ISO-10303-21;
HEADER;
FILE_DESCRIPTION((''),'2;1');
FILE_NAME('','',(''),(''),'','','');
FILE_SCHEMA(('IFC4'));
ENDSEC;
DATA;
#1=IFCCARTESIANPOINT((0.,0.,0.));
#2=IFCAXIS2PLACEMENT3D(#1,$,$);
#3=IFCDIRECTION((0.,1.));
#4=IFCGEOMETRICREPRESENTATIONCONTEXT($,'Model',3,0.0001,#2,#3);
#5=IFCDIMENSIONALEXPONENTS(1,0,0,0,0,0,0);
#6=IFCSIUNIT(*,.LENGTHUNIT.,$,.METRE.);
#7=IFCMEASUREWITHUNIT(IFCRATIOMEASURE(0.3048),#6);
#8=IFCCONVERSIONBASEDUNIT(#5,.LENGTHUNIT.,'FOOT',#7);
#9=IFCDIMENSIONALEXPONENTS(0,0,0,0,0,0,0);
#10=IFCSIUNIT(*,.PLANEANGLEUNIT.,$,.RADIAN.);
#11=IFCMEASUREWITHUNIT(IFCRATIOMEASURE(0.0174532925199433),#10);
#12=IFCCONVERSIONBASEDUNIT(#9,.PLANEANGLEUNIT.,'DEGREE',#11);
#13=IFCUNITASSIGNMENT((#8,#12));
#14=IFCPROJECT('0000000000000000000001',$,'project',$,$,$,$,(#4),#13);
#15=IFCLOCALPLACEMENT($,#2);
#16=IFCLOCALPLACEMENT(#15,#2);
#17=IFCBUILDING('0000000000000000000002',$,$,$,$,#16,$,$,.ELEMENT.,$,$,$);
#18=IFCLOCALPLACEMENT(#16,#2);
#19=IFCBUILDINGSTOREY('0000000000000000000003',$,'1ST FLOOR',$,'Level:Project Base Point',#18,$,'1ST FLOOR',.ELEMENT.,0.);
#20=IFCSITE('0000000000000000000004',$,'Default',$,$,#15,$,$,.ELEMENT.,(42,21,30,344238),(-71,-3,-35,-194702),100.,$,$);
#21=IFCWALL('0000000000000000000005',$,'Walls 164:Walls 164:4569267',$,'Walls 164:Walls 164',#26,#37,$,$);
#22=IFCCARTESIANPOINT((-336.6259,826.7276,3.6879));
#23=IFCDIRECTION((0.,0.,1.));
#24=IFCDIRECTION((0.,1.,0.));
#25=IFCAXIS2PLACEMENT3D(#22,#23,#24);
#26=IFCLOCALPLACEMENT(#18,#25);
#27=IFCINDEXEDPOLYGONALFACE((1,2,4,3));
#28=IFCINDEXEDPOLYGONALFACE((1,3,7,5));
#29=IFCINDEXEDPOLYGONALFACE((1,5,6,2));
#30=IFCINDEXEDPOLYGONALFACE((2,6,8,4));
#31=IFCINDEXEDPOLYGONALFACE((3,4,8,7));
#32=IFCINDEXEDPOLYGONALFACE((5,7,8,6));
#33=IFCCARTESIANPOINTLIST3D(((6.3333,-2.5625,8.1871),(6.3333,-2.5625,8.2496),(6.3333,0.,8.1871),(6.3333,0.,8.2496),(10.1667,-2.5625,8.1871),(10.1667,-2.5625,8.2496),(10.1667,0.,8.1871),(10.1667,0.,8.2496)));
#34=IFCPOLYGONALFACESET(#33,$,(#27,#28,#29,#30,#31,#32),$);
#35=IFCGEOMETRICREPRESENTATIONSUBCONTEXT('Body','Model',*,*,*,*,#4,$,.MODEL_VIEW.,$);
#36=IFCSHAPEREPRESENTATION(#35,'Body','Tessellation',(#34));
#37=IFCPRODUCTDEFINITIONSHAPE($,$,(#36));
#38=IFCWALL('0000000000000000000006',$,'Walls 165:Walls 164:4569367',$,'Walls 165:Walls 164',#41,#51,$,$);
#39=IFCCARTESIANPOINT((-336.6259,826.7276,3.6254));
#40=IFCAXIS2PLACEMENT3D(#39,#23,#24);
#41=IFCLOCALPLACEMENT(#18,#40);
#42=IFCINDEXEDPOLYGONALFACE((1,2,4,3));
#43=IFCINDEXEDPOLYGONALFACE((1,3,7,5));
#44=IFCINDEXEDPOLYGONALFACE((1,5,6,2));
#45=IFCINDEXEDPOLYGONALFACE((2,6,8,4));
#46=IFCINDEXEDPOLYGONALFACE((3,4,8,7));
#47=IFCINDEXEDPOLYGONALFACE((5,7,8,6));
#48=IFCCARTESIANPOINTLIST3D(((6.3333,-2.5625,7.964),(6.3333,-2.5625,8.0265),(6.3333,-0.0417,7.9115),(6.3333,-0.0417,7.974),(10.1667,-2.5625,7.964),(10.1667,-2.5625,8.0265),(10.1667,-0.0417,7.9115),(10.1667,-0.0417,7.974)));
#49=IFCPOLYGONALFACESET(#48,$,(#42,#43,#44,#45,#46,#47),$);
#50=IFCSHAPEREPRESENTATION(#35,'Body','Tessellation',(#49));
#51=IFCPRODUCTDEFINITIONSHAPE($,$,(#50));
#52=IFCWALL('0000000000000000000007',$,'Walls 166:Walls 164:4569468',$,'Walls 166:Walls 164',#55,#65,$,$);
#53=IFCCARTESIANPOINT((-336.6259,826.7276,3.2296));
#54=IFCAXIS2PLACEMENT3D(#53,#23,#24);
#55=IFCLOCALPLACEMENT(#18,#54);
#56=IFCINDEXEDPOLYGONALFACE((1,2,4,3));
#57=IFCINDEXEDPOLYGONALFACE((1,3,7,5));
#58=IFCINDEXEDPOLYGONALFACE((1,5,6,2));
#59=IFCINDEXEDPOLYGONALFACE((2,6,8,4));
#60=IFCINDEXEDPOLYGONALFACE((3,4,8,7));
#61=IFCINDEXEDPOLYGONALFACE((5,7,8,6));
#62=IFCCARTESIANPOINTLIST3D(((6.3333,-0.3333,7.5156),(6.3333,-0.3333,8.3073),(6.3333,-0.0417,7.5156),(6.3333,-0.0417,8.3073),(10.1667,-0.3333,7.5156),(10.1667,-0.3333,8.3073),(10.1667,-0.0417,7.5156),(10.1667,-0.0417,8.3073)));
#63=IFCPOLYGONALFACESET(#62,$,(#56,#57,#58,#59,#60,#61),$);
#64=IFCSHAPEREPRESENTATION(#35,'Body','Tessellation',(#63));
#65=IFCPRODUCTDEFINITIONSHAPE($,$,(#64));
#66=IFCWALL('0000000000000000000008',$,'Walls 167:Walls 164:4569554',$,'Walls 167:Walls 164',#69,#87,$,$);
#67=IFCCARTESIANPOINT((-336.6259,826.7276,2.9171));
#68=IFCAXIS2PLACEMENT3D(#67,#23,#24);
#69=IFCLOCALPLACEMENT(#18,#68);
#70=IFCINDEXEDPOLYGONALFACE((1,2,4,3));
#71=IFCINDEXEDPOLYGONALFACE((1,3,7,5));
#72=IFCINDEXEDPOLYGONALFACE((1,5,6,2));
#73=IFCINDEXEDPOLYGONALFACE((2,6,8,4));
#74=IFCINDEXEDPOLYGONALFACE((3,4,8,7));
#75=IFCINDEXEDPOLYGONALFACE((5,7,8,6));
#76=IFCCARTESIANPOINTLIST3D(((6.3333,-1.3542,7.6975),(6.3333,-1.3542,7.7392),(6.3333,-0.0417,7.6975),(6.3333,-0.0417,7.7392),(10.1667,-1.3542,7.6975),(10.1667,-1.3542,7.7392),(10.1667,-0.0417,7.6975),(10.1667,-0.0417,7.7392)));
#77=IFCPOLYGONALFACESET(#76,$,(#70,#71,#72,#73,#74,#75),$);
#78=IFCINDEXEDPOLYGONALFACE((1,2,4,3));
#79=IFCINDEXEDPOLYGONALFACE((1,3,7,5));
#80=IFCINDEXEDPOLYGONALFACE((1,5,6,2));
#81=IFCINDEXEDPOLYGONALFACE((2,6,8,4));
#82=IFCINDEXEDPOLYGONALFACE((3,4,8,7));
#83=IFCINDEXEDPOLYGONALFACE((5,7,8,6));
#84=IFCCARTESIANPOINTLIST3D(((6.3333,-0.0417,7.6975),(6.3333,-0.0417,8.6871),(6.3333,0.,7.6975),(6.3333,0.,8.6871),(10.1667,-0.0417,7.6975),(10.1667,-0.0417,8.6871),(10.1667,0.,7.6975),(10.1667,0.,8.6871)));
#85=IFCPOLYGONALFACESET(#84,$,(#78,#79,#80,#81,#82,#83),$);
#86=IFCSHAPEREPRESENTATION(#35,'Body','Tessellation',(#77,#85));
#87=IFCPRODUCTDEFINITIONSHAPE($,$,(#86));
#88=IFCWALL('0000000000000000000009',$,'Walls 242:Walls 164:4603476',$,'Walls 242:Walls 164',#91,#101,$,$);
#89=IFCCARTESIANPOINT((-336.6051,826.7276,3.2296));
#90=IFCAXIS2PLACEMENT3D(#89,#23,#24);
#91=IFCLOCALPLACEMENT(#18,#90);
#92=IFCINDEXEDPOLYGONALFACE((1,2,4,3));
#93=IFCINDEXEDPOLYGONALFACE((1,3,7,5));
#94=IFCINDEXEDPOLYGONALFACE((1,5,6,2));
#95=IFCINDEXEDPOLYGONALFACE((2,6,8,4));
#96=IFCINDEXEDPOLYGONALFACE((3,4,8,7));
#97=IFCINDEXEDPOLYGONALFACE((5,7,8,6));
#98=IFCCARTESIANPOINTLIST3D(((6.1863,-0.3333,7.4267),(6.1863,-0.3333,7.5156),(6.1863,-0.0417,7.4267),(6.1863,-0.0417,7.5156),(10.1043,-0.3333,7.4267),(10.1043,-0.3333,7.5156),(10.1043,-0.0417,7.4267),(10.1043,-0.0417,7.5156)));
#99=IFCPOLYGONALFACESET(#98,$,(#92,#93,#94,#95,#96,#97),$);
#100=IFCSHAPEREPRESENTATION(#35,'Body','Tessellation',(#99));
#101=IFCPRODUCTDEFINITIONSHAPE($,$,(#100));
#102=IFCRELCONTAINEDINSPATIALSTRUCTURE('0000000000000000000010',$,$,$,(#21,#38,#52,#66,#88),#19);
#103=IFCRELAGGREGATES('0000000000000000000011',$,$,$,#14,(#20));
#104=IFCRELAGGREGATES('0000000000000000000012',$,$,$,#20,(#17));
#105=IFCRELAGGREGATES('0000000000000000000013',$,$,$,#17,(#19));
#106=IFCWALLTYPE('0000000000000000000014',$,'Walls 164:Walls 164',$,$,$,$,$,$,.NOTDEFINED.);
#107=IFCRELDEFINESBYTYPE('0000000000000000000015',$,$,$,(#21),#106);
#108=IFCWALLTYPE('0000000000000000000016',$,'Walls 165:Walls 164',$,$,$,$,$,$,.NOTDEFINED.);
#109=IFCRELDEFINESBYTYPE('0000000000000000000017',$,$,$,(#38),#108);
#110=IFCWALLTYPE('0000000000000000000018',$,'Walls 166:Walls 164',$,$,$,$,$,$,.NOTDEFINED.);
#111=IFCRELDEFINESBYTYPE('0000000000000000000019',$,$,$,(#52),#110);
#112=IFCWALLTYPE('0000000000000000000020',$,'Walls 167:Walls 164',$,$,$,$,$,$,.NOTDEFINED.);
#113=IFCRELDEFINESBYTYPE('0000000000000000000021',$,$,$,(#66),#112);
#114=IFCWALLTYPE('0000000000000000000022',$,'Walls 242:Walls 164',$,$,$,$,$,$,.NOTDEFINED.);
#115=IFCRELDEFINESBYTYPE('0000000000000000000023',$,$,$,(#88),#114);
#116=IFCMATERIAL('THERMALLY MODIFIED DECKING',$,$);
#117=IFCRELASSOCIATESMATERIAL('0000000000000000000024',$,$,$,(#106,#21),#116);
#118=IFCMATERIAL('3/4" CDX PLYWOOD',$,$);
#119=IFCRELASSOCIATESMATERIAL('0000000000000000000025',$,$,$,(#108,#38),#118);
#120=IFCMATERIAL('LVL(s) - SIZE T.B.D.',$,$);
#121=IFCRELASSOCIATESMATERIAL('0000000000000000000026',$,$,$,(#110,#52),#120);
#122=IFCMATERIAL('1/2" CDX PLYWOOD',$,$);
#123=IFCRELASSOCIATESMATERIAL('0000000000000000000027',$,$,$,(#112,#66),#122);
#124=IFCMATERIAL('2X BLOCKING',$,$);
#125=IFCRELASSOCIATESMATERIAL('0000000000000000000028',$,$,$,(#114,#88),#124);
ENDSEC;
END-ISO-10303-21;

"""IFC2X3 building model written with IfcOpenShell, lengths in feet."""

from ifc_helpers import new_model, entity, si_unit, converted_unit, direction, frame, frame_2d, origin, place, context, subcontext, project, spatial, rectangle, extrude, material, type_object, element, save


model = new_model("IFC2X3")

# Units and contexts
model_context = context("Model", 3, precision=0.0001, world=origin(), true_north=direction((0.0, 1.0)))
body_context = subcontext(model_context, "Body", "Model", "MODEL_VIEW")
ifc_project = project(units=[converted_unit("LENGTHUNIT", "FOOT", entity("IfcRatioMeasure", 0.3048), si_unit("LENGTHUNIT", "METRE"), dimensions=[1, 0, 0, 0, 0, 0, 0]), converted_unit("PLANEANGLEUNIT", "DEGREE", entity("IfcRatioMeasure", 0.0174532925199433), si_unit("PLANEANGLEUNIT", "RADIAN"), dimensions=[0, 0, 0, 0, 0, 0, 0])], contexts=[model_context])

# Site, building, storey
site_placement = place(None, origin())
site = spatial("IfcSite", under=ifc_project, at=site_placement, Name="Default", CompositionType="ELEMENT", RefLatitude=(42, 21, 30, 344238), RefLongitude=(-71, -3, -35, -194702), RefElevation=100.0)
building_placement = place(site_placement, origin())
building = spatial("IfcBuilding", under=site, at=building_placement, CompositionType="ELEMENT")
storey_placement = place(building_placement, origin())
storey = spatial("IfcBuildingStorey", under=building, at=storey_placement, Name="1ST FLOOR", ObjectType="Level:Project Base Point", LongName="1ST FLOOR", CompositionType="ELEMENT", Elevation=0.0)

# Walls
ifc_material_1 = material(Name="1/2\" CDX PLYWOOD")
ifc_material_2 = material(Name="LVL(s) - SIZE T.B.D.")
ifc_material_3 = material(Name="2X BLOCKING")
ifc_material_4 = material(Name="THERMALLY MODIFIED DECKING")
wall_type_1 = type_object("IfcWallType", Name="Walls 164:Walls 164", PredefinedType="NOTDEFINED", material=ifc_material_4)
wall_1_placement = place(storey_placement, frame((-336.6259, 826.7276, 3.6879), z_axis=(0.0, 0.0, 1.0), x_axis=(0.0, 1.0, 0.0)))
element("IfcWall", 1, at=wall_1_placement, inside=storey, type_object=wall_type_1, material=ifc_material_4, Name="Walls 164:Walls 164:4569267", ObjectType="Walls 164:Walls 164", context=body_context, shape_type="SweptSolid", body=[
    extrude(rectangle(XDim=3.8333, YDim=2.5625, at=frame_2d((0.0, 0.0), x_axis=(1.0, 0.0))), frame((8.25, -1.2813, 8.1871)), (0.0, 0.0, 1.0), 0.0625),
])
ifc_material_5 = material(Name="3/4\" CDX PLYWOOD")
wall_type_2 = type_object("IfcWallType", Name="Walls 165:Walls 164", PredefinedType="NOTDEFINED", material=ifc_material_5)
wall_2_placement = place(storey_placement, frame((-336.6259, 826.7276, 3.6254), z_axis=(0.0, 0.0, 1.0), x_axis=(0.0, 1.0, 0.0)))
element("IfcWall", 2, at=wall_2_placement, inside=storey, type_object=wall_type_2, material=ifc_material_5, Name="Walls 165:Walls 164:4569367", ObjectType="Walls 165:Walls 164", context=body_context, shape_type="SweptSolid", body=[
    extrude(rectangle(XDim=2.5214, YDim=3.8333, at=frame_2d((0.0, 0.0), x_axis=(0.0, 1.0))), frame((8.25, -1.3021, 7.9377), z_axis=(0.0, 0.020829, 0.999783), x_axis=(1.0, 0.0, 0.0)), (0.0, -0.020829, 0.999783), 0.0625),
])
wall_type_3 = type_object("IfcWallType", Name="Walls 166:Walls 164", PredefinedType="NOTDEFINED", material=ifc_material_2)
wall_3_placement = place(storey_placement, frame((-336.6259, 826.7276, 3.2296), z_axis=(0.0, 0.0, 1.0), x_axis=(0.0, 1.0, 0.0)))
element("IfcWall", 3, at=wall_3_placement, inside=storey, type_object=wall_type_3, material=ifc_material_2, Name="Walls 166:Walls 164:4569468", ObjectType="Walls 166:Walls 164", context=body_context, shape_type="SweptSolid", body=[
    extrude(rectangle(XDim=3.8333, YDim=0.2917, at=frame_2d((0.0, 0.0), x_axis=(1.0, 0.0))), frame((8.25, -0.1875, 7.5156)), (0.0, 0.0, 1.0), 0.7917),
])
wall_type_4 = type_object("IfcWallType", Name="Walls 167:Walls 164", PredefinedType="NOTDEFINED", material=ifc_material_1)
wall_4_placement = place(storey_placement, frame((-336.6259, 826.7276, 2.9171), z_axis=(0.0, 0.0, 1.0), x_axis=(0.0, 1.0, 0.0)))
element("IfcWall", 4, at=wall_4_placement, inside=storey, type_object=wall_type_4, material=ifc_material_1, Name="Walls 167:Walls 164:4569554", ObjectType="Walls 167:Walls 164", context=body_context, shape_type="SweptSolid", body=[
    extrude(rectangle(XDim=3.8333, YDim=1.3125, at=frame_2d((0.0, 0.0), x_axis=(1.0, 0.0))), frame((8.25, -0.6979, 7.6975)), (0.0, 0.0, 1.0), 0.0417),
    extrude(rectangle(XDim=3.8333, YDim=0.0417, at=frame_2d((0.0, 0.0), x_axis=(1.0, 0.0))), frame((8.25, -0.0208, 7.6975)), (0.0, 0.0, 1.0), 0.9896),
])
wall_type_5 = type_object("IfcWallType", Name="Walls 242:Walls 164", PredefinedType="NOTDEFINED", material=ifc_material_3)
wall_5_placement = place(storey_placement, frame((-336.6051, 826.7276, 3.2296), z_axis=(0.0, 0.0, 1.0), x_axis=(0.0, 1.0, 0.0)))
element("IfcWall", 5, at=wall_5_placement, inside=storey, type_object=wall_type_5, material=ifc_material_3, Name="Walls 242:Walls 164:4603476", ObjectType="Walls 242:Walls 164", context=body_context, shape_type="SweptSolid", body=[
    extrude(rectangle(XDim=3.918, YDim=0.2917, at=frame_2d((0.0, 0.0), x_axis=(1.0, 0.0))), frame((8.1453, -0.1875, 7.4267), z_axis=(0.0, 0.0, 1.0), x_axis=(-1.0, 0.0, 0.0)), (0.0, 0.0, 1.0), 0.089),
])

save(model, "model.ifc")
